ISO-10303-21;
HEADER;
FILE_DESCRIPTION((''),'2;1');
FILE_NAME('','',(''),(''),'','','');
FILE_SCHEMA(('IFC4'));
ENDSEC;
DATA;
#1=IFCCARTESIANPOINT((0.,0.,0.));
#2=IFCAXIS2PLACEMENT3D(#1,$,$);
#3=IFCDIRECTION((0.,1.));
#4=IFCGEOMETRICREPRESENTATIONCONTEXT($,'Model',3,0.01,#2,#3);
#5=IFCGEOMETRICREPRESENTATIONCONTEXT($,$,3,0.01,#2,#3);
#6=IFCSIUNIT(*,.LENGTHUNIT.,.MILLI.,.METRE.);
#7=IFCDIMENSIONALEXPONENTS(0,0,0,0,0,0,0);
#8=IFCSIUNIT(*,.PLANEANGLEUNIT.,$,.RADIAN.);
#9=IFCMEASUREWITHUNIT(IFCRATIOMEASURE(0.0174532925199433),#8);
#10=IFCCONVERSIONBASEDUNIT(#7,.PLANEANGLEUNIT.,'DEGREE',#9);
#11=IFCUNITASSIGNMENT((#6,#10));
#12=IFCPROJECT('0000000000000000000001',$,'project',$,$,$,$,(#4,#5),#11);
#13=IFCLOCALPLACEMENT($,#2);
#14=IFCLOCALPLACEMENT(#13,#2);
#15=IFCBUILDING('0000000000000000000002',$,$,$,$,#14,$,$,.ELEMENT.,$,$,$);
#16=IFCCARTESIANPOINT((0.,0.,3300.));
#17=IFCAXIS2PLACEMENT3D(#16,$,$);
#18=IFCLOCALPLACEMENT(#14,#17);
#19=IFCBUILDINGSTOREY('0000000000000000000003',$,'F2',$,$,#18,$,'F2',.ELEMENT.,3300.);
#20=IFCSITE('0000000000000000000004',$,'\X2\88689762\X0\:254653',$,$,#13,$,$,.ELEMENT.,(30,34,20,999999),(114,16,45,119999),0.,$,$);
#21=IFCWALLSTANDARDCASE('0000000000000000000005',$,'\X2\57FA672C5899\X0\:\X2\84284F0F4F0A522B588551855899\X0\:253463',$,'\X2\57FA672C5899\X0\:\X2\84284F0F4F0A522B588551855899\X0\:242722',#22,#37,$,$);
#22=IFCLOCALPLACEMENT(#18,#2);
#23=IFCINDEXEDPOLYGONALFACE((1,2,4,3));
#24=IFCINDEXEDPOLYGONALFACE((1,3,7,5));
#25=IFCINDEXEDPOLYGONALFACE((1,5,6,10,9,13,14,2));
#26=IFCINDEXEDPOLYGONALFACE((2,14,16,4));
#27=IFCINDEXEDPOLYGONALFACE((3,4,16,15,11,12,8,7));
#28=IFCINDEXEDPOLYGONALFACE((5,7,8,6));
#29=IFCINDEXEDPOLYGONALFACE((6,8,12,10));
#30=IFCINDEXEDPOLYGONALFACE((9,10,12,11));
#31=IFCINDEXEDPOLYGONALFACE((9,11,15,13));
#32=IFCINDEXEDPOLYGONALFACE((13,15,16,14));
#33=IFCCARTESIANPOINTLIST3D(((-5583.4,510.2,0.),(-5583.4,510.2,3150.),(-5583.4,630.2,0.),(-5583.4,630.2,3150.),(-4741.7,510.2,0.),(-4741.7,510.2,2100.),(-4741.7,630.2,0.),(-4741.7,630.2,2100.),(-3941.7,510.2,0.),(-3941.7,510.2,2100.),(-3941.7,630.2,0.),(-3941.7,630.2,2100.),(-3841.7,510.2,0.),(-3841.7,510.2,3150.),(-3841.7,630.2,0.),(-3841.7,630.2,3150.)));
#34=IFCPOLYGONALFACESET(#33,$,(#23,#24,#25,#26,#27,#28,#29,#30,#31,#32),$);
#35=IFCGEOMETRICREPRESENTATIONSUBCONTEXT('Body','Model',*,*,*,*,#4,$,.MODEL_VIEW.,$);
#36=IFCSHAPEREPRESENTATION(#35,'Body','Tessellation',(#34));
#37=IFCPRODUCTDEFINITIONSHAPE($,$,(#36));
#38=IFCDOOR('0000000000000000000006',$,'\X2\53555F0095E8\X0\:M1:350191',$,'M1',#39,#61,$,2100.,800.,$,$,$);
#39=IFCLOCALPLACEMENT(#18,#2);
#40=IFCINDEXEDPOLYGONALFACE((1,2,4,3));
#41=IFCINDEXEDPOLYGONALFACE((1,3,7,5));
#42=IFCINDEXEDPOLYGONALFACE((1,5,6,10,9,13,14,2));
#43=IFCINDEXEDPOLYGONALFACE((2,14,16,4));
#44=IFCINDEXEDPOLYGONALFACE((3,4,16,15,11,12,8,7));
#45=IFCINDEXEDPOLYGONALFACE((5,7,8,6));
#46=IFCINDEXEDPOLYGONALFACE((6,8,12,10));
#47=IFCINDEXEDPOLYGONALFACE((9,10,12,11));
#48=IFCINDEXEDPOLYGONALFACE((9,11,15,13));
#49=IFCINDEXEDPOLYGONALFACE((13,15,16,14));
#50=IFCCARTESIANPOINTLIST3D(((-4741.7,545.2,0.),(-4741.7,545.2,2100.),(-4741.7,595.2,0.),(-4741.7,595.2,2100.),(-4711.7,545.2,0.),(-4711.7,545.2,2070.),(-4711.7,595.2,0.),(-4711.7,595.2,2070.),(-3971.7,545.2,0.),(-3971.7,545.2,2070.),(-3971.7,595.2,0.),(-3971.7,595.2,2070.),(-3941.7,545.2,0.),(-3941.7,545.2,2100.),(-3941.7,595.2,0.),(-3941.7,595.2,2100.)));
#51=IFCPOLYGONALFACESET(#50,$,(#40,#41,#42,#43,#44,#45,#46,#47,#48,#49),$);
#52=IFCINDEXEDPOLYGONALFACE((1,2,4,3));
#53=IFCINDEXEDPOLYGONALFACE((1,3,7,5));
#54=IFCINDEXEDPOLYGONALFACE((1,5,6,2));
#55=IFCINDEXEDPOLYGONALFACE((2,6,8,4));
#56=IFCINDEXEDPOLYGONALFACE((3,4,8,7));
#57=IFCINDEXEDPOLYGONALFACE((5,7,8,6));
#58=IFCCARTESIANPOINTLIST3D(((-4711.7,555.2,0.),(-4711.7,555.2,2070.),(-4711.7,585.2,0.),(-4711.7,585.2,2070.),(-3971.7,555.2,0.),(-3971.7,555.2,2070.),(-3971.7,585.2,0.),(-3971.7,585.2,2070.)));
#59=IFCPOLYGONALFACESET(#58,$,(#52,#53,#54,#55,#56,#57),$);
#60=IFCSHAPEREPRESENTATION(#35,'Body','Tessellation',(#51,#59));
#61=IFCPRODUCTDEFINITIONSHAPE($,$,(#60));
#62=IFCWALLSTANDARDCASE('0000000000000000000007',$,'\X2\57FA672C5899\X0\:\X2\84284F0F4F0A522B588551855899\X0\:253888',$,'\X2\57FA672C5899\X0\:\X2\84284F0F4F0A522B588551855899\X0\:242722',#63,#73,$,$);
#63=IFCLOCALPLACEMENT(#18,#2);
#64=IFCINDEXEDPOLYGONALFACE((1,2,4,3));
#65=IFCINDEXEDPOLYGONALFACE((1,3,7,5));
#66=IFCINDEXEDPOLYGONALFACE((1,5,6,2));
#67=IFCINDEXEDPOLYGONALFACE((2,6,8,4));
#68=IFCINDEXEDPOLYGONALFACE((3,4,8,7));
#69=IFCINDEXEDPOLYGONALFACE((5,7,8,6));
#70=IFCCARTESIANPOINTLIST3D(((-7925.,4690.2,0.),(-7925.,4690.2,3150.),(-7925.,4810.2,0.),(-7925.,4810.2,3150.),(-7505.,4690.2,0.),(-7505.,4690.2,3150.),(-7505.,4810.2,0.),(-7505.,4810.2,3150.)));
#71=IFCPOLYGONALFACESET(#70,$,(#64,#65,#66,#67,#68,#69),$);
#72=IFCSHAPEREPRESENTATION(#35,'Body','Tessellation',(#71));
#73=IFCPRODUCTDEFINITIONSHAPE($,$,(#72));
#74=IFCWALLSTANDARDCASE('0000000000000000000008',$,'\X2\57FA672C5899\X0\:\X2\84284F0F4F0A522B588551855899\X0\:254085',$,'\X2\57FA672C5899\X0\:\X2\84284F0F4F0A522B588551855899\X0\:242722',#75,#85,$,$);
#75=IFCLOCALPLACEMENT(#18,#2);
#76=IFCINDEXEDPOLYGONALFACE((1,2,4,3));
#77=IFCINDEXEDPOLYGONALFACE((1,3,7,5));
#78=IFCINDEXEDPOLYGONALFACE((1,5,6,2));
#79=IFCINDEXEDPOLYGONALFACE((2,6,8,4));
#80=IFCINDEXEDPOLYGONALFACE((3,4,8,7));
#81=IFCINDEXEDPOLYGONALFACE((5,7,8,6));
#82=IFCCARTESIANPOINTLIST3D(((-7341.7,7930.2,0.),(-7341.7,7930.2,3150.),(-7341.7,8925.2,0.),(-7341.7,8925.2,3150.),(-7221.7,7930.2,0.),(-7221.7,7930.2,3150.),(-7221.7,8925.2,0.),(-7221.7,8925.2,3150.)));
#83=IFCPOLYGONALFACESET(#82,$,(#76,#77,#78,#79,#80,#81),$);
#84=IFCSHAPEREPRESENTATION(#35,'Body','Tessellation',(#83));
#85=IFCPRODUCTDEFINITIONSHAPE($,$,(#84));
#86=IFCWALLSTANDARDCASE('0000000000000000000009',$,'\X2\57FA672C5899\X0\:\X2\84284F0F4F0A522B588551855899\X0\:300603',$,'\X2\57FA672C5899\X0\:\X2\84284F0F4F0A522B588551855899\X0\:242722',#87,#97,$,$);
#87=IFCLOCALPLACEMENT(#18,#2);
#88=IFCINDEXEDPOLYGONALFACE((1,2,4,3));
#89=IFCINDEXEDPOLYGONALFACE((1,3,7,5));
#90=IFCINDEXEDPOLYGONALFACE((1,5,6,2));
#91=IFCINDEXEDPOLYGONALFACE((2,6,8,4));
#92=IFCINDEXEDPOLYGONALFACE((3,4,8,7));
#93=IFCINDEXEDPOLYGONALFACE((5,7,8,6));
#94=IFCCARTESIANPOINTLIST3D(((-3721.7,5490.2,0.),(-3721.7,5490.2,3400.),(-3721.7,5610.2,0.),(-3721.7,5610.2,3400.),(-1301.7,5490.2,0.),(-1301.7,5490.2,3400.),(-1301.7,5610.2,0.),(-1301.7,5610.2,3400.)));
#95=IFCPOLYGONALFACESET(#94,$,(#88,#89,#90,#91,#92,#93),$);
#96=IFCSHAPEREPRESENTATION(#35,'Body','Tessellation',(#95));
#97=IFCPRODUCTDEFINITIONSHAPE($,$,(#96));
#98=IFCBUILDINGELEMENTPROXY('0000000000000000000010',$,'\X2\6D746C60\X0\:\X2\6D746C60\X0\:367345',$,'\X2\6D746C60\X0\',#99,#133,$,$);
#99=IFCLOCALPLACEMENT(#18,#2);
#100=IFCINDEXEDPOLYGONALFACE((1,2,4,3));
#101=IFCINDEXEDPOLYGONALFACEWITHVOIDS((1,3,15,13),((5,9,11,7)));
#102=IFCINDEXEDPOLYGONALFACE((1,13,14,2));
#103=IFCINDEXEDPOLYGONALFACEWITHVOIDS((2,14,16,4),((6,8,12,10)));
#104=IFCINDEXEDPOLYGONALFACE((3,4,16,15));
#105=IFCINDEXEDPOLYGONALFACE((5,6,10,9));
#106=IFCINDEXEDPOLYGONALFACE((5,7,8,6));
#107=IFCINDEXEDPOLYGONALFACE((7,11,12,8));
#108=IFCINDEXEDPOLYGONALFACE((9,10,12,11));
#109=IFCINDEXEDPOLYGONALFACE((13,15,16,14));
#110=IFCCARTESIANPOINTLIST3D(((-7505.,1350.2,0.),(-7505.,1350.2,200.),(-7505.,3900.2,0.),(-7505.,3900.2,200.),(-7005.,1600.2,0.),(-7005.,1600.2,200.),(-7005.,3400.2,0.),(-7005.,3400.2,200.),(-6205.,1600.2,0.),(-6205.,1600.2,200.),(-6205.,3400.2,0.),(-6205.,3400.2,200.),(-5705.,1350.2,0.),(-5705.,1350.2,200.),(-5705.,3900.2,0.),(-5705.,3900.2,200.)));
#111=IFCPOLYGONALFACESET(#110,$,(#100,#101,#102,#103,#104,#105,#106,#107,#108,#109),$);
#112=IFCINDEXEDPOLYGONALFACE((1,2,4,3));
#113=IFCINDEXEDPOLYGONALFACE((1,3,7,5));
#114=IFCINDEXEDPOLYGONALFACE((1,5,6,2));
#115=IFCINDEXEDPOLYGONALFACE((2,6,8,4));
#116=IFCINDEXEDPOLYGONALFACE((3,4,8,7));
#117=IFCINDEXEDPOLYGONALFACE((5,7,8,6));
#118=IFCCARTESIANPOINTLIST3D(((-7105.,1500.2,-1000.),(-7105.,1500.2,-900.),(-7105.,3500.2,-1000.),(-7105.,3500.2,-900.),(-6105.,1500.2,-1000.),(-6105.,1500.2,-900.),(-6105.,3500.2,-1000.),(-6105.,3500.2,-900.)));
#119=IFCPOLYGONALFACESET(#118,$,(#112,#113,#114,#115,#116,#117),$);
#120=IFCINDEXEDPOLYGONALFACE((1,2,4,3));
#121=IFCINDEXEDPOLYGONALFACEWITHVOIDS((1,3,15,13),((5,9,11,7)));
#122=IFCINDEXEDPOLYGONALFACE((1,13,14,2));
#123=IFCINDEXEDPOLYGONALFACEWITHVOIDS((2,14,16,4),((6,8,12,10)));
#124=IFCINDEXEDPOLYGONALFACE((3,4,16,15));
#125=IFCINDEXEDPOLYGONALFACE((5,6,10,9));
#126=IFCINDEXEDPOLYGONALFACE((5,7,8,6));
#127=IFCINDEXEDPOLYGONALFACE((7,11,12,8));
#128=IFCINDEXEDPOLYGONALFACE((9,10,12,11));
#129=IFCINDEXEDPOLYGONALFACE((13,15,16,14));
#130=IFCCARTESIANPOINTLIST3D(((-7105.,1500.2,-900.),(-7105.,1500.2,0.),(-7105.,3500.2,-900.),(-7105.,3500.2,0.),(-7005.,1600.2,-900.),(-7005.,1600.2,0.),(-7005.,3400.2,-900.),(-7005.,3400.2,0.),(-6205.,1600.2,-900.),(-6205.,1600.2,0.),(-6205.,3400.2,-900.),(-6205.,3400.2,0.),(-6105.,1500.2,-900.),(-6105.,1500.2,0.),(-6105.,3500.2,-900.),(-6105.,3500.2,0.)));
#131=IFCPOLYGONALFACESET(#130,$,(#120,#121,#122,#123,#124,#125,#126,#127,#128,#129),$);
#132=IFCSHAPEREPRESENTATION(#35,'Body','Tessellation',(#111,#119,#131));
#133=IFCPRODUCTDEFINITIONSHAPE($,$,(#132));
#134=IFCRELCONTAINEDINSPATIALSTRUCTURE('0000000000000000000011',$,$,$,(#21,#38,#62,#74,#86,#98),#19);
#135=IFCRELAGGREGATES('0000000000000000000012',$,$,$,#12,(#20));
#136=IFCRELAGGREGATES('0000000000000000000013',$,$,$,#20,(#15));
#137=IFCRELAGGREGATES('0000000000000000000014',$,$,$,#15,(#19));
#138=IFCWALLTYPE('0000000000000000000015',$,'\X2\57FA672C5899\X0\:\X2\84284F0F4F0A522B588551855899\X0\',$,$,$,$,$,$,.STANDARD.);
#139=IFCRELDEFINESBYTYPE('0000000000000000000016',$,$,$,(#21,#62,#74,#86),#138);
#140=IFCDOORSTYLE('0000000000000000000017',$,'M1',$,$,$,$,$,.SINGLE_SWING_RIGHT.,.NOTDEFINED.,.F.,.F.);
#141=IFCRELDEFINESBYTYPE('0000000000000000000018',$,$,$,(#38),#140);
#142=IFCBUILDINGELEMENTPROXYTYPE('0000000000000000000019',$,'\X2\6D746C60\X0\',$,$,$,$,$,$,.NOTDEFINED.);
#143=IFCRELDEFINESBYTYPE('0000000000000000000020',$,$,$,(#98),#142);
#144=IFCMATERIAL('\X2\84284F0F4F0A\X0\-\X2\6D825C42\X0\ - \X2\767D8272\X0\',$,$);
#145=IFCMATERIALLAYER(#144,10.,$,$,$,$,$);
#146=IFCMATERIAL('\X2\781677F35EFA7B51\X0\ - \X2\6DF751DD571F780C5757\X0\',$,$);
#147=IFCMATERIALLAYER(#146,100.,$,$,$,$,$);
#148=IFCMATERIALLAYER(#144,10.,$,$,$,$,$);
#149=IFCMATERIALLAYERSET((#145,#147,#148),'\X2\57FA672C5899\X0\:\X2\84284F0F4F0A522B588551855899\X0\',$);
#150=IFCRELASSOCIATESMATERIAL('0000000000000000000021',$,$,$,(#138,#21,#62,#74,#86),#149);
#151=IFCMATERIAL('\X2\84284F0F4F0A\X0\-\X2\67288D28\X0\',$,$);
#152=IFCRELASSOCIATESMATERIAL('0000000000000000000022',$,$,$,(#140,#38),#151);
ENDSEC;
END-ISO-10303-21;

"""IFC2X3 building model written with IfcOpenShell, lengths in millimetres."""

from ifc_helpers import new_model, entity, si_unit, converted_unit, direction, frame, frame_2d, origin, origin_2d_with_axis, place, context, subcontext, project, spatial, polyline, rectangle, outline, extrude, clip, bounded_halfspace, source, transform, mapped, material, layer, layer_set, layer_usage, type_object, type_shapes, element, fill, save


model = new_model("IFC2X3")

# Units and contexts
model_context = context("Model", 3, precision=0.01, world=origin(), true_north=direction((0.0, 1.0)))
context_of_model = context(None, 3, precision=0.01, world=origin(), true_north=direction((0.0, 1.0)))
body_context = subcontext(model_context, "Body", "Model", "MODEL_VIEW")
ifc_project = project(units=[si_unit("LENGTHUNIT", "METRE", prefix="MILLI"), converted_unit("PLANEANGLEUNIT", "DEGREE", entity("IfcRatioMeasure", 0.0174532925199433), si_unit("PLANEANGLEUNIT", "RADIAN"), dimensions=[0, 0, 0, 0, 0, 0, 0])], contexts=[model_context, context_of_model])

# Site, building, storey
site_placement = place(None, origin())
site = spatial("IfcSite", under=ifc_project, at=site_placement, Name="表面:254653", CompositionType="ELEMENT", RefLatitude=(30, 34, 20, 999999), RefLongitude=(114, 16, 45, 119999), RefElevation=0.0)
building_placement = place(site_placement, origin())
building = spatial("IfcBuilding", under=site, at=building_placement, CompositionType="ELEMENT")
storey_placement = place(building_placement, frame((0.0, 0.0, 3300.0)))
storey = spatial("IfcBuildingStorey", under=building, at=storey_placement, Name="F2", LongName="F2", CompositionType="ELEMENT", Elevation=3300.0)

# Wall, opening, door
ifc_material_1 = material(Name="萨伏伊-涂层 - 白色")
ifc_layer_1 = layer(ifc_material_1, 10.0)
ifc_material_2 = material(Name="砖石建筑 - 混凝土砌块")
ifc_layer_2 = layer(ifc_material_2, 100.0)
ifc_layer_3 = layer(ifc_material_1, 10.0)
ifc_layer_set = layer_set([ifc_layer_1, ifc_layer_2, ifc_layer_3], Name="基本墙:萨伏伊别墅内墙")
ifc_layer_usage_1 = layer_usage(ifc_layer_set, "AXIS2", "POSITIVE", -60.0)
wall_type = type_object("IfcWallType", Name="基本墙:萨伏伊别墅内墙", PredefinedType="STANDARD", material=ifc_layer_set)
wall_1_placement = place(storey_placement, frame((-5583.4, 570.2, 0.0)))
wall_1 = element("IfcWallStandardCase", 1, at=wall_1_placement, inside=storey, type_object=wall_type, material=ifc_layer_usage_1, Name="基本墙:萨伏伊别墅内墙:253463", ObjectType="基本墙:萨伏伊别墅内墙:242722", context=body_context, shape_type="Clipping", body=[
    clip(extrude(rectangle(XDim=1741.7, YDim=120.0, at=frame_2d((870.8, 0.0), x_axis=(-1.0, 0.0))), origin(), (0.0, 0.0, 1.0), 3150.0), bounded_halfspace(frame((0.0, 60.0, 3150.0), z_axis=(0.0, 0.0, -1.0), x_axis=(0.0, -1.0, 0.0)), True, frame((0.0, 60.0, 3150.0)), polyline([(0.0, 0.0), (0.0, -120.0), (1741.7, -120.0), (1741.7, 0.0), (0.0, 0.0)]))),
])
opening_1_placement = place(wall_1_placement, frame((841.7, -60.0, 0.0)))
opening_1 = element("IfcOpeningElement", 2, at=opening_1_placement, cuts=wall_1, ObjectType="Opening", context=body_context, shape_type="SweptSolid", body=[
    extrude(rectangle(XDim=2100.0, YDim=800.0, at=frame_2d((1050.0, 400.0), x_axis=(1.0, 0.0))), frame((0.0, 0.0, 0.0), z_axis=(0.0, 1.0, 0.0), x_axis=(0.0, 0.0, 1.0)), (0.0, 0.0, 1.0), 120.0),
])
ifc_material_3 = material(Name="萨伏伊-木质")
door_style = type_object("IfcDoorStyle", Name="M1", ConstructionType="NOTDEFINED", OperationType="SINGLE_SWING_RIGHT", ParameterTakesPrecedence=False, Sizeable=False, material=ifc_material_3)
shared_shape_1 = source(origin(), body_context, "Body", "SweptSolid", [
    extrude(outline(polyline([(-1057.5, -400.0), (1042.5, -400.0), (1042.5, -370.0), (-1027.5, -370.0), (-1027.5, 370.0), (1042.5, 370.0), (1042.5, 400.0), (-1057.5, 400.0), (-1057.5, -400.0)])), frame((400.0, 85.0, 1042.5), z_axis=(0.0, -1.0, 0.0), x_axis=(0.0, 0.0, -1.0)), (0.0, 0.0, 1.0), 50.0),
    extrude(rectangle(XDim=740.0, YDim=30.0, at=origin_2d_with_axis()), frame((400.0, 60.0, 0.0)), (0.0, 0.0, 1.0), 2070.0),
])
type_shapes(door_style, [shared_shape_1])
door_placement = place(opening_1_placement, origin())
door = element("IfcDoor", 3, at=door_placement, inside=storey, type_object=door_style, material=ifc_material_3, Name="单开门:M1:350191", ObjectType="M1", OverallHeight=2100.0, OverallWidth=800.0, context=body_context, shape_type="MappedRepresentation", body=[
    mapped(shared_shape_1, transform((0.0, 0.0, 0.0), scale=1.0)),
])
fill(opening_1, door)

# Walls
ifc_layer_usage_2 = layer_usage(ifc_layer_set, "AXIS2", "NEGATIVE", 60.0)
wall_2_placement = place(storey_placement, frame((-7505.0, 4750.2, 0.0), z_axis=(0.0, 0.0, 1.0), x_axis=(-1.0, 0.0, 0.0)))
element("IfcWallStandardCase", 4, at=wall_2_placement, inside=storey, type_object=wall_type, material=ifc_layer_usage_2, Name="基本墙:萨伏伊别墅内墙:253888", ObjectType="基本墙:萨伏伊别墅内墙:242722", context=body_context, shape_type="Clipping", body=[
    clip(extrude(rectangle(XDim=420.0, YDim=120.0, at=frame_2d((210.0, 0.0), x_axis=(-1.0, 0.0))), origin(), (0.0, 0.0, 1.0), 3150.0), bounded_halfspace(frame((0.0, -60.0, 3150.0), z_axis=(0.0, 0.0, -1.0), x_axis=(0.0, 1.0, 0.0)), True, frame((0.0, -60.0, 3150.0)), polyline([(0.0, 0.0), (300.0, 0.0), (420.0, 0.0), (420.0, 120.0), (0.0, 120.0), (0.0, 0.0)]))),
])
ifc_layer_usage_3 = layer_usage(ifc_layer_set, "AXIS2", "NEGATIVE", 60.0)
wall_3_placement = place(storey_placement, frame((-7281.7, 7930.2, 0.0), z_axis=(0.0, 0.0, 1.0), x_axis=(0.0, 1.0, 0.0)))
element("IfcWallStandardCase", 5, at=wall_3_placement, inside=storey, type_object=wall_type, material=ifc_layer_usage_3, Name="基本墙:萨伏伊别墅内墙:254085", ObjectType="基本墙:萨伏伊别墅内墙:242722", context=body_context, shape_type="Clipping", body=[
    clip(extrude(rectangle(XDim=995.0, YDim=120.0, at=frame_2d((497.5, 0.0), x_axis=(-1.0, 0.0))), origin(), (0.0, 0.0, 1.0), 3150.0), bounded_halfspace(frame((0.0, -60.0, 3150.0), z_axis=(0.0, 0.0, -1.0), x_axis=(-1.0, 0.0, 0.0)), True, frame((0.0, -60.0, 3150.0)), polyline([(0.0, 0.0), (995.0, 0.0), (995.0, 120.0), (0.0, 120.0), (0.0, 0.0)]))),
])

# Wall
ifc_layer_usage_4 = layer_usage(ifc_layer_set, "AXIS2", "NEGATIVE", 60.0)
wall_4_placement = place(storey_placement, frame((-3721.7, 5550.2, 0.0)))
element("IfcWallStandardCase", 6, at=wall_4_placement, inside=storey, type_object=wall_type, material=ifc_layer_usage_4, Name="基本墙:萨伏伊别墅内墙:300603", ObjectType="基本墙:萨伏伊别墅内墙:242722", context=body_context, shape_type="SweptSolid", body=[
    extrude(rectangle(XDim=2420.0, YDim=120.0, at=frame_2d((1210.0, 0.0), x_axis=(-1.0, 0.0))), origin(), (0.0, 0.0, 1.0), 3400.0),
])

# Building element proxy
building_element_proxy_type = type_object("IfcBuildingElementProxyType", Name="浴池", PredefinedType="NOTDEFINED")
shared_shape_2 = source(origin(), body_context, "Body", "SweptSolid", [
    extrude(outline(polyline([(-900.0, -1275.0), (900.0, -1275.0), (900.0, 1275.0), (-900.0, 1275.0), (-900.0, -1275.0)]), holes=[polyline([(-400.0, -775.0), (-400.0, 1025.0), (400.0, 1025.0), (400.0, -775.0), (-400.0, -775.0)])]), frame((0.0, 125.0, 0.0), z_axis=(0.0, 0.0, 1.0), x_axis=(-1.0, 0.0, 0.0)), (0.0, 0.0, 1.0), 200.0),
    extrude(rectangle(XDim=2000.0, YDim=1000.0, at=origin_2d_with_axis()), frame((0.0, 0.0, -1000.0), z_axis=(0.0, 0.0, 1.0), x_axis=(0.0, 1.0, 0.0)), (0.0, 0.0, 1.0), 100.0),
    extrude(outline(polyline([(-1000.0, -500.0), (1000.0, -500.0), (1000.0, 500.0), (-1000.0, 500.0), (-1000.0, -500.0)]), holes=[polyline([(-900.0, 400.0), (900.0, 400.0), (900.0, -400.0), (-900.0, -400.0), (-900.0, 400.0)])]), frame((0.0, 0.0, -900.0), z_axis=(0.0, 0.0, 1.0), x_axis=(0.0, -1.0, 0.0)), (0.0, 0.0, 1.0), 900.0),
])
type_shapes(building_element_proxy_type, [shared_shape_2])
proxy_placement = place(storey_placement, frame((-6605.0, 2500.2, 0.0)))
element("IfcBuildingElementProxy", 7, at=proxy_placement, inside=storey, type_object=building_element_proxy_type, Name="浴池:浴池:367345", ObjectType="浴池", context=body_context, shape_type="MappedRepresentation", body=[
    mapped(shared_shape_2, transform((0.0, 0.0, 0.0), scale=1.0)),
])

save(model, "model.ifc")
